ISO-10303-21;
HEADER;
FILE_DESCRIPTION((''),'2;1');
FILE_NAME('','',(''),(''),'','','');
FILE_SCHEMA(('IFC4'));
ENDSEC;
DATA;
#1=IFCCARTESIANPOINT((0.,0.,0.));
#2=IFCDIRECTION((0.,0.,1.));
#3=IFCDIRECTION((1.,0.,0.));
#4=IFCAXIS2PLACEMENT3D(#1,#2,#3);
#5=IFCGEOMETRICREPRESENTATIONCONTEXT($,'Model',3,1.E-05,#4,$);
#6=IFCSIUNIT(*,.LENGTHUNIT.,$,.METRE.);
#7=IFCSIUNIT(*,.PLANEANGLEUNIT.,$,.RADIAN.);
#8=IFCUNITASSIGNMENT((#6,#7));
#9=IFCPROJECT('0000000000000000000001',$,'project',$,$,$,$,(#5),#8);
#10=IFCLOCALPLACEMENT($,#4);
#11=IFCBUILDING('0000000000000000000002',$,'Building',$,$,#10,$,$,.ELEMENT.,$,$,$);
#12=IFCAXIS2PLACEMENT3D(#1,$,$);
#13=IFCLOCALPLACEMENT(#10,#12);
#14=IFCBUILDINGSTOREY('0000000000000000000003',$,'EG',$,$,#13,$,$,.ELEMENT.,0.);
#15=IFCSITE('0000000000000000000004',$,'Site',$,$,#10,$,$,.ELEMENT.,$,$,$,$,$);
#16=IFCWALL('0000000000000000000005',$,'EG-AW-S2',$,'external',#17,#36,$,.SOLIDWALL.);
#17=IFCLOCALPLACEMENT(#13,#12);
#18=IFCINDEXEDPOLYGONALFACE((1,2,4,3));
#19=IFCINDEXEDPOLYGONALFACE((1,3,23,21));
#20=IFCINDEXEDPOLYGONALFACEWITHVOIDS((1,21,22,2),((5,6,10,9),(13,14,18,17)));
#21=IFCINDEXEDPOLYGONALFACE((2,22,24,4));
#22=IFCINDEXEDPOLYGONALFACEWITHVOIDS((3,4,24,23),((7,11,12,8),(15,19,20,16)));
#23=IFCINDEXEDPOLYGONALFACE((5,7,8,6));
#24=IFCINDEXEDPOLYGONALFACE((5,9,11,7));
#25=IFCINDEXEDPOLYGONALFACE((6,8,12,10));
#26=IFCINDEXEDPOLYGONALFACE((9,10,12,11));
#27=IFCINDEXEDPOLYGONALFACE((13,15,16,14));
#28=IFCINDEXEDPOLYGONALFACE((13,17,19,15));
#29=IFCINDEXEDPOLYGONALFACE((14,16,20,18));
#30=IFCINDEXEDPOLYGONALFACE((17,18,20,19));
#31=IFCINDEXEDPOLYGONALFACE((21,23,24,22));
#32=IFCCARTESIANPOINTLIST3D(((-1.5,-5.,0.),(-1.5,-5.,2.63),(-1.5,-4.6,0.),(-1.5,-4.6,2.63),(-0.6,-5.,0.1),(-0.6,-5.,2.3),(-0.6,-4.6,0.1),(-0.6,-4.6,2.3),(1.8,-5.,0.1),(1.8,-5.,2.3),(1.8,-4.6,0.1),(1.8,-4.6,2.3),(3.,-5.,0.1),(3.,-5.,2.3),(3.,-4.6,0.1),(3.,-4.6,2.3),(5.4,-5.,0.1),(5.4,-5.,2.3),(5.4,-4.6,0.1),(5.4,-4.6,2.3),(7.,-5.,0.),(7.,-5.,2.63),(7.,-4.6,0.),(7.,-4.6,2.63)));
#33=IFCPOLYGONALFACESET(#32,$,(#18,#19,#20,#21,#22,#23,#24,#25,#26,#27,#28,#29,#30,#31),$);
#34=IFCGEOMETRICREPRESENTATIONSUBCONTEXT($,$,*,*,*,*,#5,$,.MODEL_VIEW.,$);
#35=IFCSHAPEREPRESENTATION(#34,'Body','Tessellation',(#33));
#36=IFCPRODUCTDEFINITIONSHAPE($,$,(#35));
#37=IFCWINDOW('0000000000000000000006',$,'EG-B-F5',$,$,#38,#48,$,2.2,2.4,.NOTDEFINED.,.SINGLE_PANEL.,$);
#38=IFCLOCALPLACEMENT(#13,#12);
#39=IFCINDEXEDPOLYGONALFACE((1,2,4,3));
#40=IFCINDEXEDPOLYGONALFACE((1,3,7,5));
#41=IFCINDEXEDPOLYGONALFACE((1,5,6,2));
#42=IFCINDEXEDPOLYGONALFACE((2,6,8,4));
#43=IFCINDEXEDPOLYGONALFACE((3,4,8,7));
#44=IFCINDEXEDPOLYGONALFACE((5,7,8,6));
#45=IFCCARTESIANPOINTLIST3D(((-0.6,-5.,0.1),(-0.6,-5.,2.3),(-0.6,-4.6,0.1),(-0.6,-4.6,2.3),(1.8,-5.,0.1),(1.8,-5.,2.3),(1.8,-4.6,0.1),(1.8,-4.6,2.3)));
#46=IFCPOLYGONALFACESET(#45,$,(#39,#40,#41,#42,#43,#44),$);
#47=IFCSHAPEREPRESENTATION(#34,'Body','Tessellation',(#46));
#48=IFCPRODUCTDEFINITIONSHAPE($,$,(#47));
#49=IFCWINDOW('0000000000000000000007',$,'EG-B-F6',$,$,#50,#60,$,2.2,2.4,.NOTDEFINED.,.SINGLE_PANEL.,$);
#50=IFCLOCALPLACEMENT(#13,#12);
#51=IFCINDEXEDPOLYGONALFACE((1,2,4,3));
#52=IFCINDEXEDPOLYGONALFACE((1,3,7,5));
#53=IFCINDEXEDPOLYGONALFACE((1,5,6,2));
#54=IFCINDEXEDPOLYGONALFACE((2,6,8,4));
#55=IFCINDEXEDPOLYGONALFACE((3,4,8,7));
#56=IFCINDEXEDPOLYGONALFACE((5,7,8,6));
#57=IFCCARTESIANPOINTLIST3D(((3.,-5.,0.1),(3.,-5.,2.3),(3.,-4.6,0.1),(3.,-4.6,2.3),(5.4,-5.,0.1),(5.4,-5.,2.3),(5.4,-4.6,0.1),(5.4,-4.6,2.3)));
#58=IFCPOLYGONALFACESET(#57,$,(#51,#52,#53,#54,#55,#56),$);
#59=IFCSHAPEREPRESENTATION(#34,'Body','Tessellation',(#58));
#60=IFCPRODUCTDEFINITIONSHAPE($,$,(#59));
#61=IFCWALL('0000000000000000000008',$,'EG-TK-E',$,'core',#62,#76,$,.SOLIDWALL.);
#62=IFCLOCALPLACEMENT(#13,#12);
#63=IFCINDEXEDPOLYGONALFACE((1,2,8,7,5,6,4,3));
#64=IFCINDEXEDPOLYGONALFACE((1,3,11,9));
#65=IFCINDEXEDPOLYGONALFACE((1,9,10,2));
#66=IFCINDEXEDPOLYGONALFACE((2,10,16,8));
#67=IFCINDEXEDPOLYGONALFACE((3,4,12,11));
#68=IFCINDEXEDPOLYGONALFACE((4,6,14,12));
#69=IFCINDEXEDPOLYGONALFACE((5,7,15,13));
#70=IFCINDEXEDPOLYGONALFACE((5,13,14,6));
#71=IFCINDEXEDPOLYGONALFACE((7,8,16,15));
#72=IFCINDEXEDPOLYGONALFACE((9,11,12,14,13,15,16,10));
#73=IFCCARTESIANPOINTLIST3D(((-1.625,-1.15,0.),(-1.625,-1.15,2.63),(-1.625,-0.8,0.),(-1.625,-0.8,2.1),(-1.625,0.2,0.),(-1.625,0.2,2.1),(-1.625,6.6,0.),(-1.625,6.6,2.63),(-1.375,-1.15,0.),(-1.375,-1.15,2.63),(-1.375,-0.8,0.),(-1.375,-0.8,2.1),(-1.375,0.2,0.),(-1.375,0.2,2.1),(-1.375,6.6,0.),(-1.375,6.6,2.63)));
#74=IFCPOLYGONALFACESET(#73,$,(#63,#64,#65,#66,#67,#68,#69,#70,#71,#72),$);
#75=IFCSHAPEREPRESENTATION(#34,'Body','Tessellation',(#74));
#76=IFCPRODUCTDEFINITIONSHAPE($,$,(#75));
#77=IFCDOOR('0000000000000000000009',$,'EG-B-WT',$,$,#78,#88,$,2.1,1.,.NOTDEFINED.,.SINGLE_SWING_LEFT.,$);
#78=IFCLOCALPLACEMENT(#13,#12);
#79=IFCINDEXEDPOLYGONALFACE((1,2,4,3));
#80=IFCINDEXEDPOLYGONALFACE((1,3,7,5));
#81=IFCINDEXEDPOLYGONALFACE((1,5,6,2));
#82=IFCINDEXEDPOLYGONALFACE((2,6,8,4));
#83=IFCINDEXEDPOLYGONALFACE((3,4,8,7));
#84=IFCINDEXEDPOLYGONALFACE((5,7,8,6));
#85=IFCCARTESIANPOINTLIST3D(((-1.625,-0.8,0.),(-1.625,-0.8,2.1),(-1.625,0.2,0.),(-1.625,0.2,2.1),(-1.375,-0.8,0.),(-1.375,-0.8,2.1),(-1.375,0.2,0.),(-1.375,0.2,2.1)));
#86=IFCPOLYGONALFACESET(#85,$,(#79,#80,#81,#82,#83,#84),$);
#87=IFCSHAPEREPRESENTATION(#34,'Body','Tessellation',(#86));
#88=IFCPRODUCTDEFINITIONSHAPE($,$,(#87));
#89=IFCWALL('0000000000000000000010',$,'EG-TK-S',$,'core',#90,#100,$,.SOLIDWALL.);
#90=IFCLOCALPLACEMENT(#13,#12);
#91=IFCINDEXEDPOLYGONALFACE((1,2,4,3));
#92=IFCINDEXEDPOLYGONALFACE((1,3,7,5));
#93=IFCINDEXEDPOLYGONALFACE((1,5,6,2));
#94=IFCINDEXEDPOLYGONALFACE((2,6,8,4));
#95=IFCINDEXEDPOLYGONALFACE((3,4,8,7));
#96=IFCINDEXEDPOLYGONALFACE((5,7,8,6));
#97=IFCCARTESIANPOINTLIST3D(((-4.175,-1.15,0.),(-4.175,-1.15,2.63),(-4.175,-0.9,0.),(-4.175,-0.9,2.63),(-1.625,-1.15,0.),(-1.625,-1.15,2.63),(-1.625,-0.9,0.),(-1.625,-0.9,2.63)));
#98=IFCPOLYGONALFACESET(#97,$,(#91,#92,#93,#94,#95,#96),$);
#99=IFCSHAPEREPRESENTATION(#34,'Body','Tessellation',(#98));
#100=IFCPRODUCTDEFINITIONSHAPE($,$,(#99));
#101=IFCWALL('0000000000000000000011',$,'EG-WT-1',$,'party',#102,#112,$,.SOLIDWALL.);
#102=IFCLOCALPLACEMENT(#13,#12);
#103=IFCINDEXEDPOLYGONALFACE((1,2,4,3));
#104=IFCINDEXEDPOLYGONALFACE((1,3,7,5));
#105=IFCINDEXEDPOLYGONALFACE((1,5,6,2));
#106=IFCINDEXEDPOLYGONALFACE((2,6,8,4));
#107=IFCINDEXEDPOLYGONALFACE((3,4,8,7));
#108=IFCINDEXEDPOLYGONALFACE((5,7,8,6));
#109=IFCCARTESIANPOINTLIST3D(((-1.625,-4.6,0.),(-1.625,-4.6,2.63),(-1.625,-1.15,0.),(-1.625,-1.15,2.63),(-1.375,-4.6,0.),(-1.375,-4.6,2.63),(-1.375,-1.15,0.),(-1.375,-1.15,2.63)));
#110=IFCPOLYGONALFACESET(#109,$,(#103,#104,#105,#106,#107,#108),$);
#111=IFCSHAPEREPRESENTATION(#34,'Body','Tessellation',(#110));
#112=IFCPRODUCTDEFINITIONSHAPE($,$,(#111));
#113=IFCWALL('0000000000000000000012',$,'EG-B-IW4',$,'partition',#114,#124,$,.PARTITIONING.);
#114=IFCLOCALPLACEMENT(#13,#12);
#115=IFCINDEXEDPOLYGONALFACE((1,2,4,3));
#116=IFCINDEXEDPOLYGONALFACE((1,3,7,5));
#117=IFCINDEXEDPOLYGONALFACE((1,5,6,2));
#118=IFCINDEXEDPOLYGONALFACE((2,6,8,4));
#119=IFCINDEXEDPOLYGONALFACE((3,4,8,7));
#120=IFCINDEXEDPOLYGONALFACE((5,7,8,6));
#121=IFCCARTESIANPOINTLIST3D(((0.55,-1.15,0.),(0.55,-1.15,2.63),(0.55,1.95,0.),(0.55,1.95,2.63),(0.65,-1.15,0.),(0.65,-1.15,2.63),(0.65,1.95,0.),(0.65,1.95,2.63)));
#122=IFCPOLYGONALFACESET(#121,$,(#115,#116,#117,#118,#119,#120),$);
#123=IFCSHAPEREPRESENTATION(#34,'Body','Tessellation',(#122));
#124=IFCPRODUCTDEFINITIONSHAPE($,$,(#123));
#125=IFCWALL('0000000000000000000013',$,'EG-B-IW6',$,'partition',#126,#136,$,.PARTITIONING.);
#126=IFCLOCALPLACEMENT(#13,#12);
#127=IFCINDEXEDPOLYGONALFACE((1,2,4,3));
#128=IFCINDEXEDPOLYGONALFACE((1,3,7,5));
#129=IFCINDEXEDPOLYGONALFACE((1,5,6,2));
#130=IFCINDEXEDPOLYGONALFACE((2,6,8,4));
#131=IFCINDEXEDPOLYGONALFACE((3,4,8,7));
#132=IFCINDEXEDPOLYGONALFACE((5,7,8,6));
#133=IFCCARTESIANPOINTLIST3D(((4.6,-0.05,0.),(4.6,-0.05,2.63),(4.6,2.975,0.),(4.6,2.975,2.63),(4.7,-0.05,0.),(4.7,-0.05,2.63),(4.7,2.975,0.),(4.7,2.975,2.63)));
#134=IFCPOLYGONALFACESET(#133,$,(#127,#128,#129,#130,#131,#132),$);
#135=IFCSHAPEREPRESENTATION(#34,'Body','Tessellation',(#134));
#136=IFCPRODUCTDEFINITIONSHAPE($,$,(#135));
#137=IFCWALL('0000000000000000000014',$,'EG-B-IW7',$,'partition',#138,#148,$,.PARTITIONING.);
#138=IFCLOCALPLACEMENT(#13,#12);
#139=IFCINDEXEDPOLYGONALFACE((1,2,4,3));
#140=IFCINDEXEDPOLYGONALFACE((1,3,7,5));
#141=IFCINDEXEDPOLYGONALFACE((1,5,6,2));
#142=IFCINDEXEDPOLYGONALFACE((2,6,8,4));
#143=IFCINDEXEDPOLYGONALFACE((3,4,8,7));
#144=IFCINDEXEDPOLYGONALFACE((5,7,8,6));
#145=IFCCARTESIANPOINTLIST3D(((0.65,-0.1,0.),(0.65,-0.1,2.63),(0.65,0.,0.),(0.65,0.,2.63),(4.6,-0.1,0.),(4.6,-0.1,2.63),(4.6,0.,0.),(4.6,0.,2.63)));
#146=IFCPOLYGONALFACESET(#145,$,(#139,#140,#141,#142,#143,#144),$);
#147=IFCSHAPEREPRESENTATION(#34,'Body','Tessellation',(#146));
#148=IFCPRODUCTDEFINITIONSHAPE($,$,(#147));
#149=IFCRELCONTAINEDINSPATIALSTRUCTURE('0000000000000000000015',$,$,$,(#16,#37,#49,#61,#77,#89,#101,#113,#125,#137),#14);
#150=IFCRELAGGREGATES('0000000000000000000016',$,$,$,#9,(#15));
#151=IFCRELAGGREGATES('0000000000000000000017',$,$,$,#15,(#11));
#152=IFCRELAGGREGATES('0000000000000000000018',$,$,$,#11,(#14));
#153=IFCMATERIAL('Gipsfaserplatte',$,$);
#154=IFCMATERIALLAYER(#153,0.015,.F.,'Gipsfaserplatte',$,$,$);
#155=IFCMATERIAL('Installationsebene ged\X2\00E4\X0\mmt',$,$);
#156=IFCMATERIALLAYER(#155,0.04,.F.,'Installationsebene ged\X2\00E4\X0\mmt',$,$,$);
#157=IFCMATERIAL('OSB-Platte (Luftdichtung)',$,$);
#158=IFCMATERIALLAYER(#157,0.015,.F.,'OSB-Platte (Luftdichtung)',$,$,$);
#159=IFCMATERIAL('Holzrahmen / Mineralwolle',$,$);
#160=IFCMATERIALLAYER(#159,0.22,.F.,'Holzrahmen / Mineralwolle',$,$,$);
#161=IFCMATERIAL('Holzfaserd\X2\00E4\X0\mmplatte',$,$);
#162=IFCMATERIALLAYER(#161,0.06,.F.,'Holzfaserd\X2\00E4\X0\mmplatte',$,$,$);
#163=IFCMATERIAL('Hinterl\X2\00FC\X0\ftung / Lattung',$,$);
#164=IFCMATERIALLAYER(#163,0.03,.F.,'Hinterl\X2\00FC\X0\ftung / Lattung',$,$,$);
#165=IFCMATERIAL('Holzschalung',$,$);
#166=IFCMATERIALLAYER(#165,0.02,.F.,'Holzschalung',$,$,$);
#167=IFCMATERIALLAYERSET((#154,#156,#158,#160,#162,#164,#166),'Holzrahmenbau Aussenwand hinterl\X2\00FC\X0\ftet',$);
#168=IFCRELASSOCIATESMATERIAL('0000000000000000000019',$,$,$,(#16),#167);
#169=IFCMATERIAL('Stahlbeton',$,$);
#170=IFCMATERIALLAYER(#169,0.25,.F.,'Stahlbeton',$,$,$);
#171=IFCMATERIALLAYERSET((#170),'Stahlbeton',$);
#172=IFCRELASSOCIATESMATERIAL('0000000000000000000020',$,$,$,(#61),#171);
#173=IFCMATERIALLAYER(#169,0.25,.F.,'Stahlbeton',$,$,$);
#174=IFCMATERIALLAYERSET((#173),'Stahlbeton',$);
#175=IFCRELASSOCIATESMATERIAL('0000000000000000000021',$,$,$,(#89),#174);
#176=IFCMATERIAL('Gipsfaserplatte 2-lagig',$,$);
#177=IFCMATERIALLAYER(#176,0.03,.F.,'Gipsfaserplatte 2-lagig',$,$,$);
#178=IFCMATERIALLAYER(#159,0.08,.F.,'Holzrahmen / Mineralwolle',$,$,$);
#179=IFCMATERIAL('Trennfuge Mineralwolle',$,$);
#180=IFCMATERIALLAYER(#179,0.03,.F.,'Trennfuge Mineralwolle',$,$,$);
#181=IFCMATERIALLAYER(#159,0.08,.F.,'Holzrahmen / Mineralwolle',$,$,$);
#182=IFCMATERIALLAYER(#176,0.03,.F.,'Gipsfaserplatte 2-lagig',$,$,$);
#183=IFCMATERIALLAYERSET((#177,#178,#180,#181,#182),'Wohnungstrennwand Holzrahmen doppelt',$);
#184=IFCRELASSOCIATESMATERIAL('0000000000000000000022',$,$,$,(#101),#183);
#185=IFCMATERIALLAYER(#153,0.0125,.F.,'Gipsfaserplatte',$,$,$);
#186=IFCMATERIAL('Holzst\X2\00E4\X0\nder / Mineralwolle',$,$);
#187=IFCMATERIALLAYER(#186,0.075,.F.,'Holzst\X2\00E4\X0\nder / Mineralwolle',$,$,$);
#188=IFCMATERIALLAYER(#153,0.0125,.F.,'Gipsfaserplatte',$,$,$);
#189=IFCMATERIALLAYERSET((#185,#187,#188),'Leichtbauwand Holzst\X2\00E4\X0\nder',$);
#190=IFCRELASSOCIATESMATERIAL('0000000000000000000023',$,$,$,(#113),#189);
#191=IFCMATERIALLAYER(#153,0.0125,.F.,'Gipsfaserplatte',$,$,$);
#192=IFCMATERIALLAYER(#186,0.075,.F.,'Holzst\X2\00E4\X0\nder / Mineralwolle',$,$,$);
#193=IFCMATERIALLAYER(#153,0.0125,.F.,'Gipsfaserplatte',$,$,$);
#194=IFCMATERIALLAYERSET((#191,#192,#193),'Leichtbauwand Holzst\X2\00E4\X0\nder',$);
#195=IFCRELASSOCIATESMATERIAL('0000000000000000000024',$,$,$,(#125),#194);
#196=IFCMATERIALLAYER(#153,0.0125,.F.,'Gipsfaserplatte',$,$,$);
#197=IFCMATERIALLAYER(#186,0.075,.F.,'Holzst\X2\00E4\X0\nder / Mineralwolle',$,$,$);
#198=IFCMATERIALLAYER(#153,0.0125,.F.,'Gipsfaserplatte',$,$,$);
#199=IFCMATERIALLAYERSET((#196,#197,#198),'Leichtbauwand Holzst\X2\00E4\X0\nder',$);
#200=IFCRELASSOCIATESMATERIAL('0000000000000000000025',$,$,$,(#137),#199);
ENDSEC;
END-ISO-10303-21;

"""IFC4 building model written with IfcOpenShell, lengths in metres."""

from ifc_helpers import new_model, si_unit, frame, frame_2d, origin, origin_with_axes, place, context, subcontext, project, spatial, rectangle, extrude, material, layer, layer_set, element, fill, save


model = new_model("IFC4")

# Units and contexts
model_context = context("Model", 3, precision=1e-05, world=origin_with_axes())
sub_context = subcontext(model_context, None, None, "MODEL_VIEW")
ifc_project = project(units=[si_unit("LENGTHUNIT", "METRE"), si_unit("PLANEANGLEUNIT", "RADIAN")], contexts=[model_context])

# Site, building, storey
placement = place(None, origin_with_axes())
site = spatial("IfcSite", under=ifc_project, at=placement, Name="Site", CompositionType="ELEMENT")
building = spatial("IfcBuilding", under=site, at=placement, Name="Building", CompositionType="ELEMENT")
storey_placement = place(placement, origin())
storey = spatial("IfcBuildingStorey", under=building, at=storey_placement, Name="EG", CompositionType="ELEMENT", Elevation=0.0)

# Wall, openings, windows
ifc_material_1 = material(Name="Gipsfaserplatte")
ifc_layer_1 = layer(ifc_material_1, 0.015, ventilated=False, Name="Gipsfaserplatte")
ifc_material_2 = material(Name="Installationsebene gedämmt")
ifc_layer_2 = layer(ifc_material_2, 0.04, ventilated=False, Name="Installationsebene gedämmt")
ifc_material_3 = material(Name="OSB-Platte (Luftdichtung)")
ifc_layer_3 = layer(ifc_material_3, 0.015, ventilated=False, Name="OSB-Platte (Luftdichtung)")
ifc_material_4 = material(Name="Holzrahmen / Mineralwolle")
ifc_layer_4 = layer(ifc_material_4, 0.22, ventilated=False, Name="Holzrahmen / Mineralwolle")
ifc_material_5 = material(Name="Holzfaserdämmplatte")
ifc_layer_5 = layer(ifc_material_5, 0.06, ventilated=False, Name="Holzfaserdämmplatte")
ifc_material_6 = material(Name="Hinterlüftung / Lattung")
ifc_layer_6 = layer(ifc_material_6, 0.03, ventilated=False, Name="Hinterlüftung / Lattung")
ifc_material_7 = material(Name="Holzschalung")
ifc_layer_7 = layer(ifc_material_7, 0.02, ventilated=False, Name="Holzschalung")
ifc_layer_set_1 = layer_set([ifc_layer_1, ifc_layer_2, ifc_layer_3, ifc_layer_4, ifc_layer_5, ifc_layer_6, ifc_layer_7], Name="Holzrahmenbau Aussenwand hinterlüftet")
wall_1_placement = place(storey_placement, frame((7.0, -4.8, 0.0), z_axis=(0.0, 0.0, 1.0), x_axis=(-1.0, 0.0, 0.0)))
wall_1 = element("IfcWall", 1, at=wall_1_placement, inside=storey, material=ifc_layer_set_1, Name="EG-AW-S2", ObjectType="external", PredefinedType="SOLIDWALL", context=sub_context, shape_type="SweptSolid", body=[
    extrude(rectangle(XDim=8.5, YDim=0.4, at=frame_2d((4.25, 0.0))), origin(), (0.0, 0.0, 1.0), 2.63),
])
opening_1_placement = place(wall_1_placement, frame((6.4, 0.25, 0.1), z_axis=(0.0, -1.0, 0.0), x_axis=(1.0, 0.0, 0.0)))
opening_1 = element("IfcOpeningElement", 2, at=opening_1_placement, cuts=wall_1, PredefinedType="OPENING", context=sub_context, shape_type="SweptSolid", body=[
    extrude(rectangle(XDim=2.4, YDim=2.2, at=frame_2d((0.0, 1.1))), origin(), (0.0, 0.0, 1.0), 0.5),
])
opening_2_placement = place(wall_1_placement, frame((2.8, 0.25, 0.1), z_axis=(0.0, -1.0, 0.0), x_axis=(1.0, 0.0, 0.0)))
opening_2 = element("IfcOpeningElement", 3, at=opening_2_placement, cuts=wall_1, PredefinedType="OPENING", context=sub_context, shape_type="SweptSolid", body=[
    extrude(rectangle(XDim=2.4, YDim=2.2, at=frame_2d((0.0, 1.1))), origin(), (0.0, 0.0, 1.0), 0.5),
])
window_1_placement = place(wall_1_placement, frame((6.4, 0.2, 0.1), z_axis=(0.0, -1.0, 0.0), x_axis=(1.0, 0.0, 0.0)))
window_1 = element("IfcWindow", 4, at=window_1_placement, inside=storey, Name="EG-B-F5", OverallHeight=2.2, OverallWidth=2.4, PartitioningType="SINGLE_PANEL", PredefinedType="NOTDEFINED", context=sub_context, shape_type="SweptSolid", body=[
    extrude(rectangle(XDim=2.4, YDim=2.2, at=frame_2d((0.0, 1.1))), origin(), (0.0, 0.0, 1.0), 0.4),
])
fill(opening_1, window_1)
window_2_placement = place(wall_1_placement, frame((2.8, 0.2, 0.1), z_axis=(0.0, -1.0, 0.0), x_axis=(1.0, 0.0, 0.0)))
window_2 = element("IfcWindow", 5, at=window_2_placement, inside=storey, Name="EG-B-F6", OverallHeight=2.2, OverallWidth=2.4, PartitioningType="SINGLE_PANEL", PredefinedType="NOTDEFINED", context=sub_context, shape_type="SweptSolid", body=[
    extrude(rectangle(XDim=2.4, YDim=2.2, at=frame_2d((0.0, 1.1))), origin(), (0.0, 0.0, 1.0), 0.4),
])
fill(opening_2, window_2)

# Wall, opening, door
ifc_material_8 = material(Name="Stahlbeton")
ifc_layer_8 = layer(ifc_material_8, 0.25, ventilated=False, Name="Stahlbeton")
ifc_layer_set_2 = layer_set([ifc_layer_8], Name="Stahlbeton")
wall_2_placement = place(storey_placement, frame((-1.5, -1.15, 0.0), z_axis=(0.0, 0.0, 1.0), x_axis=(0.0, 1.0, 0.0)))
wall_2 = element("IfcWall", 6, at=wall_2_placement, inside=storey, material=ifc_layer_set_2, Name="EG-TK-E", ObjectType="core", PredefinedType="SOLIDWALL", context=sub_context, shape_type="SweptSolid", body=[
    extrude(rectangle(XDim=7.75, YDim=0.25, at=frame_2d((3.875, 0.0))), origin(), (0.0, 0.0, 1.0), 2.63),
])
opening_3_placement = place(wall_2_placement, frame((0.85, 0.175, 0.0), z_axis=(0.0, -1.0, 0.0), x_axis=(1.0, 0.0, 0.0)))
opening_3 = element("IfcOpeningElement", 7, at=opening_3_placement, cuts=wall_2, PredefinedType="OPENING", context=sub_context, shape_type="SweptSolid", body=[
    extrude(rectangle(XDim=1.0, YDim=2.1, at=frame_2d((0.0, 1.05))), origin(), (0.0, 0.0, 1.0), 0.35),
])
door_1_placement = place(wall_2_placement, frame((0.85, 0.125, 0.0), z_axis=(0.0, -1.0, 0.0), x_axis=(1.0, 0.0, 0.0)))
door_1 = element("IfcDoor", 8, at=door_1_placement, inside=storey, Name="EG-B-WT", OperationType="SINGLE_SWING_LEFT", OverallHeight=2.1, OverallWidth=1.0, PredefinedType="NOTDEFINED", context=sub_context, shape_type="SweptSolid", body=[
    extrude(rectangle(XDim=1.0, YDim=2.1, at=frame_2d((0.0, 1.05))), origin(), (0.0, 0.0, 1.0), 0.25),
])
fill(opening_3, door_1)

# Walls
ifc_layer_9 = layer(ifc_material_8, 0.25, ventilated=False, Name="Stahlbeton")
ifc_layer_set_3 = layer_set([ifc_layer_9], Name="Stahlbeton")
wall_3_placement = place(storey_placement, frame((-4.175, -1.025, 0.0), z_axis=(0.0, 0.0, 1.0), x_axis=(1.0, 0.0, 0.0)))
element("IfcWall", 9, at=wall_3_placement, inside=storey, material=ifc_layer_set_3, Name="EG-TK-S", ObjectType="core", PredefinedType="SOLIDWALL", context=sub_context, shape_type="SweptSolid", body=[
    extrude(rectangle(XDim=2.55, YDim=0.25, at=frame_2d((1.275, 0.0))), origin(), (0.0, 0.0, 1.0), 2.63),
])
ifc_material_9 = material(Name="Gipsfaserplatte 2-lagig")
ifc_layer_10 = layer(ifc_material_9, 0.03, ventilated=False, Name="Gipsfaserplatte 2-lagig")
ifc_layer_11 = layer(ifc_material_4, 0.08, ventilated=False, Name="Holzrahmen / Mineralwolle")
ifc_material_10 = material(Name="Trennfuge Mineralwolle")
ifc_layer_12 = layer(ifc_material_10, 0.03, ventilated=False, Name="Trennfuge Mineralwolle")
ifc_layer_13 = layer(ifc_material_4, 0.08, ventilated=False, Name="Holzrahmen / Mineralwolle")
ifc_layer_14 = layer(ifc_material_9, 0.03, ventilated=False, Name="Gipsfaserplatte 2-lagig")
ifc_layer_set_4 = layer_set([ifc_layer_10, ifc_layer_11, ifc_layer_12, ifc_layer_13, ifc_layer_14], Name="Wohnungstrennwand Holzrahmen doppelt")
wall_4_placement = place(storey_placement, frame((-1.5, -1.15, 0.0), z_axis=(0.0, 0.0, 1.0), x_axis=(0.0, -1.0, 0.0)))
element("IfcWall", 10, at=wall_4_placement, inside=storey, material=ifc_layer_set_4, Name="EG-WT-1", ObjectType="party", PredefinedType="SOLIDWALL", context=sub_context, shape_type="SweptSolid", body=[
    extrude(rectangle(XDim=3.45, YDim=0.25, at=frame_2d((1.725, 0.0))), origin(), (0.0, 0.0, 1.0), 2.63),
])
ifc_layer_15 = layer(ifc_material_1, 0.0125, ventilated=False, Name="Gipsfaserplatte")
ifc_material_11 = material(Name="Holzständer / Mineralwolle")
ifc_layer_16 = layer(ifc_material_11, 0.075, ventilated=False, Name="Holzständer / Mineralwolle")
ifc_layer_17 = layer(ifc_material_1, 0.0125, ventilated=False, Name="Gipsfaserplatte")
ifc_layer_set_5 = layer_set([ifc_layer_15, ifc_layer_16, ifc_layer_17], Name="Leichtbauwand Holzständer")
wall_5_placement = place(storey_placement, frame((0.6, -1.15, 0.0), z_axis=(0.0, 0.0, 1.0), x_axis=(0.0, 1.0, 0.0)))
element("IfcWall", 11, at=wall_5_placement, inside=storey, material=ifc_layer_set_5, Name="EG-B-IW4", ObjectType="partition", PredefinedType="PARTITIONING", context=sub_context, shape_type="SweptSolid", body=[
    extrude(rectangle(XDim=3.1, YDim=0.1, at=frame_2d((1.55, 0.0))), origin(), (0.0, 0.0, 1.0), 2.63),
])
ifc_layer_18 = layer(ifc_material_1, 0.0125, ventilated=False, Name="Gipsfaserplatte")
ifc_layer_19 = layer(ifc_material_11, 0.075, ventilated=False, Name="Holzständer / Mineralwolle")
ifc_layer_20 = layer(ifc_material_1, 0.0125, ventilated=False, Name="Gipsfaserplatte")
ifc_layer_set_6 = layer_set([ifc_layer_18, ifc_layer_19, ifc_layer_20], Name="Leichtbauwand Holzständer")
wall_6_placement = place(storey_placement, frame((4.65, -0.05, 0.0), z_axis=(0.0, 0.0, 1.0), x_axis=(0.0, 1.0, 0.0)))
element("IfcWall", 12, at=wall_6_placement, inside=storey, material=ifc_layer_set_6, Name="EG-B-IW6", ObjectType="partition", PredefinedType="PARTITIONING", context=sub_context, shape_type="SweptSolid", body=[
    extrude(rectangle(XDim=3.025, YDim=0.1, at=frame_2d((1.5125, 0.0))), origin(), (0.0, 0.0, 1.0), 2.63),
])
ifc_layer_21 = layer(ifc_material_1, 0.0125, ventilated=False, Name="Gipsfaserplatte")
ifc_layer_22 = layer(ifc_material_11, 0.075, ventilated=False, Name="Holzständer / Mineralwolle")
ifc_layer_23 = layer(ifc_material_1, 0.0125, ventilated=False, Name="Gipsfaserplatte")
ifc_layer_set_7 = layer_set([ifc_layer_21, ifc_layer_22, ifc_layer_23], Name="Leichtbauwand Holzständer")
wall_7_placement = place(storey_placement, frame((0.65, -0.05, 0.0), z_axis=(0.0, 0.0, 1.0), x_axis=(1.0, 0.0, 0.0)))
element("IfcWall", 13, at=wall_7_placement, inside=storey, material=ifc_layer_set_7, Name="EG-B-IW7", ObjectType="partition", PredefinedType="PARTITIONING", context=sub_context, shape_type="SweptSolid", body=[
    extrude(rectangle(XDim=3.95, YDim=0.1, at=frame_2d((1.975, 0.0))), origin(), (0.0, 0.0, 1.0), 2.63),
])

save(model, "model.ifc")
